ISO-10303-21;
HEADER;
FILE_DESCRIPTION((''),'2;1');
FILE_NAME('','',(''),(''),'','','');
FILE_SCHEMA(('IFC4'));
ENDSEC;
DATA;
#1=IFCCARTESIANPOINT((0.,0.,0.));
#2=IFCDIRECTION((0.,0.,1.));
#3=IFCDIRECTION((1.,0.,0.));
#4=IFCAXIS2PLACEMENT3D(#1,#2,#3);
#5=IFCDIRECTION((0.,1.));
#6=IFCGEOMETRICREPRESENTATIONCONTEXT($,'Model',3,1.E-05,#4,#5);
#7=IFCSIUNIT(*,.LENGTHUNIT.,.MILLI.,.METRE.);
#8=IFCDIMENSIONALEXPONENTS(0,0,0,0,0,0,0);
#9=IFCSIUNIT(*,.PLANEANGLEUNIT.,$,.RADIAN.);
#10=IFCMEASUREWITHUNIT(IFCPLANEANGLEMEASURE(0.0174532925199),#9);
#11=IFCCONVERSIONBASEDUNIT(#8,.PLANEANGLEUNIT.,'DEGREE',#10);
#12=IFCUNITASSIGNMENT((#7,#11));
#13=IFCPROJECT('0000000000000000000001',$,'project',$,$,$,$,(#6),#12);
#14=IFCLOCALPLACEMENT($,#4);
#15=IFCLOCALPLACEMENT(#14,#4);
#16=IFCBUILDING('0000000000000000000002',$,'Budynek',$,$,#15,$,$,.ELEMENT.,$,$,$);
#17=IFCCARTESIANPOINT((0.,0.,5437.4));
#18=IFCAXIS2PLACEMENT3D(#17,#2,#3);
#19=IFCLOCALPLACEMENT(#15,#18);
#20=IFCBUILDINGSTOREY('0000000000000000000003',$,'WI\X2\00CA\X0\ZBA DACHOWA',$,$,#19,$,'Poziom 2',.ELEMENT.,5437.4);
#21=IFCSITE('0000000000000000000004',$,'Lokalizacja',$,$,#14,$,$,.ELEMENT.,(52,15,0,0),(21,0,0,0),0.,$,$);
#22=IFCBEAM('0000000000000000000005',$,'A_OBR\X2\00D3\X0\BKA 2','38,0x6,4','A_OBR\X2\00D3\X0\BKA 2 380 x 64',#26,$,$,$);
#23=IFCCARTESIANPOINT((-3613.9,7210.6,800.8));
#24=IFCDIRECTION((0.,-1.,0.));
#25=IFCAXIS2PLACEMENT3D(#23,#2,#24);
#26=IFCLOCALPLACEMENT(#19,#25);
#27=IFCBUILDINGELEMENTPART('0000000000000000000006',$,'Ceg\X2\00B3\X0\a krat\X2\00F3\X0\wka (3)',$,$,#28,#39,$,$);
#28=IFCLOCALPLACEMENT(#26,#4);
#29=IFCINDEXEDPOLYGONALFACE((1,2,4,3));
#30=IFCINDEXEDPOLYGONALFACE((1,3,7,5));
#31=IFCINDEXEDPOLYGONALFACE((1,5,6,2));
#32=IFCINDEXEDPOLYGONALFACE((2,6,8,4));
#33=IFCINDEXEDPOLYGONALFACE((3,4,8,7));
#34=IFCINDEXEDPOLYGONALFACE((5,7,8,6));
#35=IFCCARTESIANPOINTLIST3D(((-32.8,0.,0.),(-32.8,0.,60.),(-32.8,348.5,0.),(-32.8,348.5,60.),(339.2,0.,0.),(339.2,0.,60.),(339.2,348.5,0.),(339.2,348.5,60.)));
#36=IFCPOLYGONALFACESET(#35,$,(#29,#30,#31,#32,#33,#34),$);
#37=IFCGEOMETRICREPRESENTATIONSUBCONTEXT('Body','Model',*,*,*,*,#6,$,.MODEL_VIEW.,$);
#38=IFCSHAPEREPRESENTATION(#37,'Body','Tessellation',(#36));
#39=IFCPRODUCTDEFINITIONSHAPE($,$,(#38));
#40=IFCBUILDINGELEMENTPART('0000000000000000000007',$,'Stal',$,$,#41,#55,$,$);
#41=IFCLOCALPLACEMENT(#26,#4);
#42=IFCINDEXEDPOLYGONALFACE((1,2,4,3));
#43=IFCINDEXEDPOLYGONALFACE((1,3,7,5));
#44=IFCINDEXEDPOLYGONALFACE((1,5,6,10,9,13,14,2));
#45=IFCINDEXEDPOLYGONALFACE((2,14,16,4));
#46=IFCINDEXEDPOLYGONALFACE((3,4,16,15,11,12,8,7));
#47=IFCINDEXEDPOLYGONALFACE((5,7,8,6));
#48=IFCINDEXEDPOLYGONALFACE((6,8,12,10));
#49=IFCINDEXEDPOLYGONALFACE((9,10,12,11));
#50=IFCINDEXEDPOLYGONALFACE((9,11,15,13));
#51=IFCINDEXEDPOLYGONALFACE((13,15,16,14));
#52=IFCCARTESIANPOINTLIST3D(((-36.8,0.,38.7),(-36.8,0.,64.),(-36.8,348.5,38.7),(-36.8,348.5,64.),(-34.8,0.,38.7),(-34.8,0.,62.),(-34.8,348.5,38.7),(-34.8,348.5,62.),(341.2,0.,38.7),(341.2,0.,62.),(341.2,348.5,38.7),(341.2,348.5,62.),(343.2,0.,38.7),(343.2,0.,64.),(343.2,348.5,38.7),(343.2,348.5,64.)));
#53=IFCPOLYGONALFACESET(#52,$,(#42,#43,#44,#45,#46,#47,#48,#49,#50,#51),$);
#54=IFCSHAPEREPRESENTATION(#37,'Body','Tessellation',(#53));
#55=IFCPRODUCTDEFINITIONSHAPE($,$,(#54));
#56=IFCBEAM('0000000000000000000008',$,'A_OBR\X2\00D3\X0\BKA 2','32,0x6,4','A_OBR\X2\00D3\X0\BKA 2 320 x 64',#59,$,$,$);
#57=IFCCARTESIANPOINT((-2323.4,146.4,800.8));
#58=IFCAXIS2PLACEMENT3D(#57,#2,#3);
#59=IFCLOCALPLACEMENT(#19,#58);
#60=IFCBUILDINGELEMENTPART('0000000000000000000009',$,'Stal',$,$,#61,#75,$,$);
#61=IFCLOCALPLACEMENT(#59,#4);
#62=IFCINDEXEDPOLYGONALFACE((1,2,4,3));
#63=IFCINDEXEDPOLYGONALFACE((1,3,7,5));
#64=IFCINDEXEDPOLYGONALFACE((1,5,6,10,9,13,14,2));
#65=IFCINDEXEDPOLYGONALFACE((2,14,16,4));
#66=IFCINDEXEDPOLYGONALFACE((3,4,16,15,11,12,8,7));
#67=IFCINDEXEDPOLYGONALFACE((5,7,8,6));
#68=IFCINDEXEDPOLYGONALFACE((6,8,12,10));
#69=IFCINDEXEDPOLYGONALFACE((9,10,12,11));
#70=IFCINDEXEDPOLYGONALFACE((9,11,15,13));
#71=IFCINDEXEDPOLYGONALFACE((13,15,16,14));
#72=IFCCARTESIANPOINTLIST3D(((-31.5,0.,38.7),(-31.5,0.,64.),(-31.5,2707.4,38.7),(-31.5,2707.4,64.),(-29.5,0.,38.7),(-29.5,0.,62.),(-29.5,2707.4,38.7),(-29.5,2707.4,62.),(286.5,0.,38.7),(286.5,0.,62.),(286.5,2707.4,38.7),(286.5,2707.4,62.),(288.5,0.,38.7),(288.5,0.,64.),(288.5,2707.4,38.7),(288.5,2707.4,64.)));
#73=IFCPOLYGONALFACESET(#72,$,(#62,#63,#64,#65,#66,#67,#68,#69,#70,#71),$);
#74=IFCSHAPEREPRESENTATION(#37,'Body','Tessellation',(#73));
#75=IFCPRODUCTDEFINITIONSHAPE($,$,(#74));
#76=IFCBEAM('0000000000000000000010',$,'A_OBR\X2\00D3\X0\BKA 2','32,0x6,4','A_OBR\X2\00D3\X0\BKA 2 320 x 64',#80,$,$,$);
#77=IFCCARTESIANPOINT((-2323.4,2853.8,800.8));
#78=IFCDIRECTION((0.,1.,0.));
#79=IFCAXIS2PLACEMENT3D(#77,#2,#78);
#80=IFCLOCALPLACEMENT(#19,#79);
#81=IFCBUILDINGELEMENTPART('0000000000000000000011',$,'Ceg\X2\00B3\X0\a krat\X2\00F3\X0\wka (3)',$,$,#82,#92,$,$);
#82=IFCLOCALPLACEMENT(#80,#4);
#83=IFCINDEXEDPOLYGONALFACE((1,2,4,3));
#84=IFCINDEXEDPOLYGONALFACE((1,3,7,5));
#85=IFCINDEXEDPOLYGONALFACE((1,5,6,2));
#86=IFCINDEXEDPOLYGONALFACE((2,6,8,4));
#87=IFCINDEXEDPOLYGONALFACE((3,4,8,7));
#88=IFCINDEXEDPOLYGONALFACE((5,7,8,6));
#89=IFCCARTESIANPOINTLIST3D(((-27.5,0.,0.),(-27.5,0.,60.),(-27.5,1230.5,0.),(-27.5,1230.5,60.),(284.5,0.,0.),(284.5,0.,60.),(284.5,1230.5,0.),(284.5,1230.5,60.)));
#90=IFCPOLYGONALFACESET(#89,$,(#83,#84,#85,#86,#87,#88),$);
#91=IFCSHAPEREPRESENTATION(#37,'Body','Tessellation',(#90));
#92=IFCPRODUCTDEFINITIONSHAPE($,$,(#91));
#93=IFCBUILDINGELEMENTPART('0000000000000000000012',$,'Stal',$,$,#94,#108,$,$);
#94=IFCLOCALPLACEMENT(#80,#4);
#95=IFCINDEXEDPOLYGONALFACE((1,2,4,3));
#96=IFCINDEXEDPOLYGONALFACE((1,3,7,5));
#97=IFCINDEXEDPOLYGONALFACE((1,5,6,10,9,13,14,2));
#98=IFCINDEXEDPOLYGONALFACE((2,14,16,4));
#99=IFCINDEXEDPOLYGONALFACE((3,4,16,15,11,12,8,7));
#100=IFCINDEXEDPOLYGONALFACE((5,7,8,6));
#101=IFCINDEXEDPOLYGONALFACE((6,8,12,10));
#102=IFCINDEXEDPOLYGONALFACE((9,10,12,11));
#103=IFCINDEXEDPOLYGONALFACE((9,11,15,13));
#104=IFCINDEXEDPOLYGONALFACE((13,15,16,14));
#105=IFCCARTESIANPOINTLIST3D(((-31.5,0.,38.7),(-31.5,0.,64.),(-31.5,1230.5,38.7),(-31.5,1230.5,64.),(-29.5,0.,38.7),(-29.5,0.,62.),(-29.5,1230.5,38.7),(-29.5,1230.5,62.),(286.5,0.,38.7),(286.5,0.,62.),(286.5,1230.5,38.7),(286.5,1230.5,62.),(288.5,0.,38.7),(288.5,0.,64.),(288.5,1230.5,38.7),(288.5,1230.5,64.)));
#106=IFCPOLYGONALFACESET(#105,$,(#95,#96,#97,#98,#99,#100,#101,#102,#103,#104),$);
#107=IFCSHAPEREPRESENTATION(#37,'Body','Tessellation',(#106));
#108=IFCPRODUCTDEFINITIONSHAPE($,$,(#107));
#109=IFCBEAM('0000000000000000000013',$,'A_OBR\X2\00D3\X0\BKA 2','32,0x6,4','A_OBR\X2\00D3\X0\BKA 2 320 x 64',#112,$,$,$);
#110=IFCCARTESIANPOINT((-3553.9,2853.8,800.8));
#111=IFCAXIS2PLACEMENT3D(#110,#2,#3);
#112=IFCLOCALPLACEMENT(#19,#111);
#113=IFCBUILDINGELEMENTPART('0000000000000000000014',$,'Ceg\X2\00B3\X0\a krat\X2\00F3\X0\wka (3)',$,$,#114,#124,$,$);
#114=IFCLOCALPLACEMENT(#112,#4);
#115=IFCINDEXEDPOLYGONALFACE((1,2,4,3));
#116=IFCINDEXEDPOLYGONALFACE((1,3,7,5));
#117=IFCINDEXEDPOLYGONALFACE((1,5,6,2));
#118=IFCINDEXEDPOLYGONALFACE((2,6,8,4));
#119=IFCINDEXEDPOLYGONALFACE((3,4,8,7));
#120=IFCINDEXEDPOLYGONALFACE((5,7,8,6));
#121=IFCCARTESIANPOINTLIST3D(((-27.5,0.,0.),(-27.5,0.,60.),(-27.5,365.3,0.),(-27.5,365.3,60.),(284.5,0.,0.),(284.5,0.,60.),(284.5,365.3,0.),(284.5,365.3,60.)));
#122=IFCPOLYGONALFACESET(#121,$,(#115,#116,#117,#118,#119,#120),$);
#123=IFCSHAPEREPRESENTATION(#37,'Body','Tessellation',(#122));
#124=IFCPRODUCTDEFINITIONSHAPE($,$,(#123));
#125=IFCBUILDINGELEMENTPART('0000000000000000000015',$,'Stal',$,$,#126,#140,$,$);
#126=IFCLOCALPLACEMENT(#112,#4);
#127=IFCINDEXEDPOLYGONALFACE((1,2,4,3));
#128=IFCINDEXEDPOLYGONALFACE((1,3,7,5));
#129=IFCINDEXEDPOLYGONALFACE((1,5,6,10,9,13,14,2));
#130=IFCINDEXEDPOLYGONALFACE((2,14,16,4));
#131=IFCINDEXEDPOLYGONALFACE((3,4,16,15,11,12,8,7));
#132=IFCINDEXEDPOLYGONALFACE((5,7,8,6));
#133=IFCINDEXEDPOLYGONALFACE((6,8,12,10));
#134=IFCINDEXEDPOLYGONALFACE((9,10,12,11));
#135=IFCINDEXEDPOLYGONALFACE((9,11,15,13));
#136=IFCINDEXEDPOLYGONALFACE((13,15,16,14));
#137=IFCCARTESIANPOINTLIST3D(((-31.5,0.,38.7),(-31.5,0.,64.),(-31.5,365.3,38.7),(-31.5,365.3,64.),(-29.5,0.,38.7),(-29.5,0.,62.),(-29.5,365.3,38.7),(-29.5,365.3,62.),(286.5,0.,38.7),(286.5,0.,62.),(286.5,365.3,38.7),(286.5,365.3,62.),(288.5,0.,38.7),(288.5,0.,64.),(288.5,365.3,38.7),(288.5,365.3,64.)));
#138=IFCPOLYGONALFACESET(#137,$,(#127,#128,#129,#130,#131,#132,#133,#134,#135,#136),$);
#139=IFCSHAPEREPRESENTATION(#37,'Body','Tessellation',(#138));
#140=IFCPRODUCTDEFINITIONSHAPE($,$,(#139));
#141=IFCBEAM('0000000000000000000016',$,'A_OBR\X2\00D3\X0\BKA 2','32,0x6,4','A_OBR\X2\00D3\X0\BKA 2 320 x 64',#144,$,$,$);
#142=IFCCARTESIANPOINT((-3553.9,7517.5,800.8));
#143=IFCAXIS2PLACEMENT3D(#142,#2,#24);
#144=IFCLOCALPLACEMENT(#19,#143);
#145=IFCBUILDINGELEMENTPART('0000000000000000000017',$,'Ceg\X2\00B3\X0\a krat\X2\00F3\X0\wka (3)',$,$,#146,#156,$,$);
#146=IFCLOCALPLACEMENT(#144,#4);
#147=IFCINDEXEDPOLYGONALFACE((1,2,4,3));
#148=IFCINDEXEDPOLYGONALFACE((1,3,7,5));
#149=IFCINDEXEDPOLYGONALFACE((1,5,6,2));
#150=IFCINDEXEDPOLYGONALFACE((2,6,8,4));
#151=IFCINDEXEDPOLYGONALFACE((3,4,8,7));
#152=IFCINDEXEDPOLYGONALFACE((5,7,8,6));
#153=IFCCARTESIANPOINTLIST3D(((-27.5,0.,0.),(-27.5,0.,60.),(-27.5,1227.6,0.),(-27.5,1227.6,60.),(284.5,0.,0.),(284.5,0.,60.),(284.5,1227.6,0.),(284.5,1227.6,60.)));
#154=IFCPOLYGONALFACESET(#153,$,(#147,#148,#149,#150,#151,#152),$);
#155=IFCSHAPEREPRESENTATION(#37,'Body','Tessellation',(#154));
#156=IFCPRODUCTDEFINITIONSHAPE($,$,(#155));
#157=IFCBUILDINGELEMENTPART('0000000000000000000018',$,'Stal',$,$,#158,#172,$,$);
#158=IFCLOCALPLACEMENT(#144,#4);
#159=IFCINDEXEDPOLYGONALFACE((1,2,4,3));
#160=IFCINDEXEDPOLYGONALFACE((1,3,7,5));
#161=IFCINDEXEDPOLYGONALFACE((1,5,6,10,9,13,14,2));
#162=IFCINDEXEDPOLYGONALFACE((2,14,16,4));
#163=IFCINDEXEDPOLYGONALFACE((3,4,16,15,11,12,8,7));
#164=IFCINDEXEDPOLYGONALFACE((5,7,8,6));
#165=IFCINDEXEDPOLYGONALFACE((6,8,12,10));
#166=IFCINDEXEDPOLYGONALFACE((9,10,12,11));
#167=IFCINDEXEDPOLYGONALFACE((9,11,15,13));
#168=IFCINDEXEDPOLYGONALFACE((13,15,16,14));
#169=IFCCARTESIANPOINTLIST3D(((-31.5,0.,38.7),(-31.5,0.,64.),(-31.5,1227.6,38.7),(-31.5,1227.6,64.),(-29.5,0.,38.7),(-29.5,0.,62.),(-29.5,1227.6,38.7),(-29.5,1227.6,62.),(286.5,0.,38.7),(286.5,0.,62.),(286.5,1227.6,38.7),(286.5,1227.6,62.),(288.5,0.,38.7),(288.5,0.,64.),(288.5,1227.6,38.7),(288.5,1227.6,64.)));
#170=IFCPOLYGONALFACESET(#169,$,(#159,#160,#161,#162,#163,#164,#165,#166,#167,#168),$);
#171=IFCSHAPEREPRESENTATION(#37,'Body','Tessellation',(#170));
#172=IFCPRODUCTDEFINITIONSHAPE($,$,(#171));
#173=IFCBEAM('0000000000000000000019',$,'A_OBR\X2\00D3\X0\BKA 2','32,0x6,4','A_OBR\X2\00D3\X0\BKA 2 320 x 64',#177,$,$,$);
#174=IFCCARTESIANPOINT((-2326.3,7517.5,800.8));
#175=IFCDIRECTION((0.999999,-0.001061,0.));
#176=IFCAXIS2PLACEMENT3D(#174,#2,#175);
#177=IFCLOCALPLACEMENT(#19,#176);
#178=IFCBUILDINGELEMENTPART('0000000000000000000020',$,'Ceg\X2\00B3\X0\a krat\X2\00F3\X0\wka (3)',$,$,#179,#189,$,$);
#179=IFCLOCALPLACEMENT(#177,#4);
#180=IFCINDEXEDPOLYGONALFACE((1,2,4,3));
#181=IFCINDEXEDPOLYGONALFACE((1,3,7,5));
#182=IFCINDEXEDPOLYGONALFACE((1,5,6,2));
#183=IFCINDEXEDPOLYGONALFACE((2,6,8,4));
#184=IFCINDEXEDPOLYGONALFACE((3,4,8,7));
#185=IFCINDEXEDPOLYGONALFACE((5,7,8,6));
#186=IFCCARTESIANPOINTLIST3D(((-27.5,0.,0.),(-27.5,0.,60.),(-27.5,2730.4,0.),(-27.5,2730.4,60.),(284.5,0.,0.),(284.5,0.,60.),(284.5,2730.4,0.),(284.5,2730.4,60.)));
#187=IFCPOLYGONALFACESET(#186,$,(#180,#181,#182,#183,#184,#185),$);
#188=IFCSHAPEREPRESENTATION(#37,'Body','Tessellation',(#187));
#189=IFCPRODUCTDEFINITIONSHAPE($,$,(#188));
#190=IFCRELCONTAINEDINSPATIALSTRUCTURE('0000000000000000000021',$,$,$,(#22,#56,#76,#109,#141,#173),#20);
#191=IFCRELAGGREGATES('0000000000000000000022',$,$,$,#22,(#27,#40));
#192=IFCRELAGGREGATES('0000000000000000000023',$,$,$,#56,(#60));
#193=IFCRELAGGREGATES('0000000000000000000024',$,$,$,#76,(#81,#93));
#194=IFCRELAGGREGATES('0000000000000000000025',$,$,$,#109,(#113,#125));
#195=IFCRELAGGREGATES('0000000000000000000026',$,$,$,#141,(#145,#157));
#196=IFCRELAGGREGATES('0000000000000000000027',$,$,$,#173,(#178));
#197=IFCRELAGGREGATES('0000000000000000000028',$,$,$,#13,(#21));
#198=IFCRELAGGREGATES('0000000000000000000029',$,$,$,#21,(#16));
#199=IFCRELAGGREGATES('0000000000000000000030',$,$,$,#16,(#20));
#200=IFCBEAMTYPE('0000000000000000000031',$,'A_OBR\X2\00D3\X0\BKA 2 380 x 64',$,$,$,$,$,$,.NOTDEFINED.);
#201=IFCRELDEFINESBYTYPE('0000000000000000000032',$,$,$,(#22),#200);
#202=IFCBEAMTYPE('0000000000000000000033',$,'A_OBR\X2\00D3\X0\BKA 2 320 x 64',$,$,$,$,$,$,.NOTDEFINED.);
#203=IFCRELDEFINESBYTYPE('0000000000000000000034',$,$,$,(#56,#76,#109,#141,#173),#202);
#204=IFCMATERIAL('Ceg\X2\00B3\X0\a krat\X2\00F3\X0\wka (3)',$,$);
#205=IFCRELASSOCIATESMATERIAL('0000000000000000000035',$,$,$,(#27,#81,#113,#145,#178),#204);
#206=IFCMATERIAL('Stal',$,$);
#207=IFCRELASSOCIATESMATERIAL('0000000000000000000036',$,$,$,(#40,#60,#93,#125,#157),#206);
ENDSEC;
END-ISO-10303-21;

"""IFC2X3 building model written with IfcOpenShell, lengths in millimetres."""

from ifc_helpers import new_model, entity, si_unit, converted_unit, direction, frame, origin_with_axes, place, context, subcontext, project, spatial, polyline, outline, extrude, material, type_object, element, aggregate, save


model = new_model("IFC2X3")

# Units and contexts
model_context = context("Model", 3, precision=1e-05, world=origin_with_axes(), true_north=direction((0.0, 1.0)))
body_context = subcontext(model_context, "Body", "Model", "MODEL_VIEW")
ifc_project = project(units=[si_unit("LENGTHUNIT", "METRE", prefix="MILLI"), converted_unit("PLANEANGLEUNIT", "DEGREE", entity("IfcPlaneAngleMeasure", 0.0174532925199), si_unit("PLANEANGLEUNIT", "RADIAN"), dimensions=[0, 0, 0, 0, 0, 0, 0])], contexts=[model_context])

# Site, building, storey
site_placement = place(None, origin_with_axes())
site = spatial("IfcSite", under=ifc_project, at=site_placement, Name="Lokalizacja", CompositionType="ELEMENT", RefLatitude=(52, 15, 0, 0), RefLongitude=(21, 0, 0, 0), RefElevation=0.0)
building_placement = place(site_placement, origin_with_axes())
building = spatial("IfcBuilding", under=site, at=building_placement, Name="Budynek", CompositionType="ELEMENT")
storey_placement = place(building_placement, frame((0.0, 0.0, 5437.4), z_axis=(0.0, 0.0, 1.0), x_axis=(1.0, 0.0, 0.0)))
storey = spatial("IfcBuildingStorey", under=building, at=storey_placement, Name="WIÊZBA DACHOWA", LongName="Poziom 2", CompositionType="ELEMENT", Elevation=5437.4)

# Beam, building element parts
beam_type_1 = type_object("IfcBeamType", Name="A_OBRÓBKA 2 380 x 64", PredefinedType="NOTDEFINED")
beam_1_placement = place(storey_placement, frame((-3613.9, 7210.6, 800.8), z_axis=(0.0, 0.0, 1.0), x_axis=(0.0, -1.0, 0.0)))
beam_1 = element("IfcBeam", 1, at=beam_1_placement, inside=storey, type_object=beam_type_1, Name="A_OBRÓBKA 2", Description="38,0x6,4", ObjectType="A_OBRÓBKA 2 380 x 64")
ifc_material_1 = material(Name="Ceg³a kratówka (3)")
building_element_part_1_placement = place(beam_1_placement, origin_with_axes())
building_element_part_1 = element("IfcBuildingElementPart", 2, at=building_element_part_1_placement, material=ifc_material_1, Name="Ceg³a kratówka (3)", context=body_context, shape_type="SweptSolid", body=[
    extrude(outline(polyline([(339.2, 0.0), (339.2, 60.0), (-32.8, 60.0), (-32.8, 0.0), (339.2, 0.0)])), frame((0.0, 348.5, 0.0), z_axis=(0.0, -1.0, 0.0), x_axis=(1.0, 0.0, 0.0)), (0.0, 0.0, 1.0), 348.5),
])
ifc_material_2 = material(Name="Stal")
building_element_part_2_placement = place(beam_1_placement, origin_with_axes())
building_element_part_2 = element("IfcBuildingElementPart", 3, at=building_element_part_2_placement, material=ifc_material_2, Name="Stal", context=body_context, shape_type="SweptSolid", body=[
    extrude(outline(polyline([(-36.8, 64.0), (-36.8, 38.7), (-34.8, 38.7), (-34.8, 62.0), (341.2, 62.0), (341.2, 38.7), (343.2, 38.7), (343.2, 64.0), (-36.8, 64.0)])), frame((0.0, 348.5, 0.0), z_axis=(0.0, -1.0, 0.0), x_axis=(1.0, 0.0, 0.0)), (0.0, 0.0, 1.0), 348.5),
])
aggregate(beam_1, [building_element_part_1, building_element_part_2])

# Beam, building element part
beam_type_2 = type_object("IfcBeamType", Name="A_OBRÓBKA 2 320 x 64", PredefinedType="NOTDEFINED")
beam_2_placement = place(storey_placement, frame((-2323.4, 146.4, 800.8), z_axis=(0.0, 0.0, 1.0), x_axis=(1.0, 0.0, 0.0)))
beam_2 = element("IfcBeam", 4, at=beam_2_placement, inside=storey, type_object=beam_type_2, Name="A_OBRÓBKA 2", Description="32,0x6,4", ObjectType="A_OBRÓBKA 2 320 x 64")
building_element_part_3_placement = place(beam_2_placement, origin_with_axes())
building_element_part_3 = element("IfcBuildingElementPart", 5, at=building_element_part_3_placement, material=ifc_material_2, Name="Stal", context=body_context, shape_type="SweptSolid", body=[
    extrude(outline(polyline([(-31.5, 64.0), (-31.5, 38.7), (-29.5, 38.7), (-29.5, 62.0), (286.5, 62.0), (286.5, 38.7), (288.5, 38.7), (288.5, 64.0), (-31.5, 64.0)])), frame((0.0, 2707.4, 0.0), z_axis=(0.0, -1.0, 0.0), x_axis=(1.0, 0.0, 0.0)), (0.0, 0.0, 1.0), 2707.4),
])
aggregate(beam_2, [building_element_part_3])

# Beams, building element parts
beam_3_placement = place(storey_placement, frame((-2323.4, 2853.8, 800.8), z_axis=(0.0, 0.0, 1.0), x_axis=(0.0, 1.0, 0.0)))
beam_3 = element("IfcBeam", 6, at=beam_3_placement, inside=storey, type_object=beam_type_2, Name="A_OBRÓBKA 2", Description="32,0x6,4", ObjectType="A_OBRÓBKA 2 320 x 64")
building_element_part_4_placement = place(beam_3_placement, origin_with_axes())
building_element_part_4 = element("IfcBuildingElementPart", 7, at=building_element_part_4_placement, material=ifc_material_1, Name="Ceg³a kratówka (3)", context=body_context, shape_type="SweptSolid", body=[
    extrude(outline(polyline([(284.5, 0.0), (284.5, 60.0), (-27.5, 60.0), (-27.5, 0.0), (284.5, 0.0)])), frame((0.0, 1230.5, 0.0), z_axis=(0.0, -1.0, 0.0), x_axis=(1.0, 0.0, 0.0)), (0.0, 0.0, 1.0), 1230.5),
])
building_element_part_5_placement = place(beam_3_placement, origin_with_axes())
building_element_part_5 = element("IfcBuildingElementPart", 8, at=building_element_part_5_placement, material=ifc_material_2, Name="Stal", context=body_context, shape_type="SweptSolid", body=[
    extrude(outline(polyline([(-31.5, 64.0), (-31.5, 38.7), (-29.5, 38.7), (-29.5, 62.0), (286.5, 62.0), (286.5, 38.7), (288.5, 38.7), (288.5, 64.0), (-31.5, 64.0)])), frame((0.0, 1230.5, 0.0), z_axis=(0.0, -1.0, 0.0), x_axis=(1.0, 0.0, 0.0)), (0.0, 0.0, 1.0), 1230.5),
])
aggregate(beam_3, [building_element_part_4, building_element_part_5])
beam_4_placement = place(storey_placement, frame((-3553.9, 2853.8, 800.8), z_axis=(0.0, 0.0, 1.0), x_axis=(1.0, 0.0, 0.0)))
beam_4 = element("IfcBeam", 9, at=beam_4_placement, inside=storey, type_object=beam_type_2, Name="A_OBRÓBKA 2", Description="32,0x6,4", ObjectType="A_OBRÓBKA 2 320 x 64")
building_element_part_6_placement = place(beam_4_placement, origin_with_axes())
building_element_part_6 = element("IfcBuildingElementPart", 10, at=building_element_part_6_placement, material=ifc_material_1, Name="Ceg³a kratówka (3)", context=body_context, shape_type="SweptSolid", body=[
    extrude(outline(polyline([(284.5, 0.0), (284.5, 60.0), (-27.5, 60.0), (-27.5, 0.0), (284.5, 0.0)])), frame((0.0, 365.3, 0.0), z_axis=(0.0, -1.0, 0.0), x_axis=(1.0, 0.0, 0.0)), (0.0, 0.0, 1.0), 365.3),
])
building_element_part_7_placement = place(beam_4_placement, origin_with_axes())
building_element_part_7 = element("IfcBuildingElementPart", 11, at=building_element_part_7_placement, material=ifc_material_2, Name="Stal", context=body_context, shape_type="SweptSolid", body=[
    extrude(outline(polyline([(-31.5, 64.0), (-31.5, 38.7), (-29.5, 38.7), (-29.5, 62.0), (286.5, 62.0), (286.5, 38.7), (288.5, 38.7), (288.5, 64.0), (-31.5, 64.0)])), frame((0.0, 365.3, 0.0), z_axis=(0.0, -1.0, 0.0), x_axis=(1.0, 0.0, 0.0)), (0.0, 0.0, 1.0), 365.3),
])
aggregate(beam_4, [building_element_part_6, building_element_part_7])
beam_5_placement = place(storey_placement, frame((-3553.9, 7517.5, 800.8), z_axis=(0.0, 0.0, 1.0), x_axis=(0.0, -1.0, 0.0)))
beam_5 = element("IfcBeam", 12, at=beam_5_placement, inside=storey, type_object=beam_type_2, Name="A_OBRÓBKA 2", Description="32,0x6,4", ObjectType="A_OBRÓBKA 2 320 x 64")
building_element_part_8_placement = place(beam_5_placement, origin_with_axes())
building_element_part_8 = element("IfcBuildingElementPart", 13, at=building_element_part_8_placement, material=ifc_material_1, Name="Ceg³a kratówka (3)", context=body_context, shape_type="SweptSolid", body=[
    extrude(outline(polyline([(284.5, 0.0), (284.5, 60.0), (-27.5, 60.0), (-27.5, 0.0), (284.5, 0.0)])), frame((0.0, 1227.6, 0.0), z_axis=(0.0, -1.0, 0.0), x_axis=(1.0, 0.0, 0.0)), (0.0, 0.0, 1.0), 1227.6),
])
building_element_part_9_placement = place(beam_5_placement, origin_with_axes())
building_element_part_9 = element("IfcBuildingElementPart", 14, at=building_element_part_9_placement, material=ifc_material_2, Name="Stal", context=body_context, shape_type="SweptSolid", body=[
    extrude(outline(polyline([(-31.5, 64.0), (-31.5, 38.7), (-29.5, 38.7), (-29.5, 62.0), (286.5, 62.0), (286.5, 38.7), (288.5, 38.7), (288.5, 64.0), (-31.5, 64.0)])), frame((0.0, 1227.6, 0.0), z_axis=(0.0, -1.0, 0.0), x_axis=(1.0, 0.0, 0.0)), (0.0, 0.0, 1.0), 1227.6),
])
aggregate(beam_5, [building_element_part_8, building_element_part_9])
beam_6_placement = place(storey_placement, frame((-2326.3, 7517.5, 800.8), z_axis=(0.0, 0.0, 1.0), x_axis=(0.999999, -0.001061, 0.0)))
beam_6 = element("IfcBeam", 15, at=beam_6_placement, inside=storey, type_object=beam_type_2, Name="A_OBRÓBKA 2", Description="32,0x6,4", ObjectType="A_OBRÓBKA 2 320 x 64")
building_element_part_10_placement = place(beam_6_placement, origin_with_axes())
building_element_part_10 = element("IfcBuildingElementPart", 16, at=building_element_part_10_placement, material=ifc_material_1, Name="Ceg³a kratówka (3)", context=body_context, shape_type="SweptSolid", body=[
    extrude(outline(polyline([(284.5, 0.0), (284.5, 60.0), (-27.5, 60.0), (-27.5, 0.0), (284.5, 0.0)])), frame((0.0, 2730.4, 0.0), z_axis=(0.0, -1.0, 0.0), x_axis=(1.0, 0.0, 0.0)), (0.0, 0.0, 1.0), 2730.4),
])
aggregate(beam_6, [building_element_part_10])

save(model, "model.ifc")
